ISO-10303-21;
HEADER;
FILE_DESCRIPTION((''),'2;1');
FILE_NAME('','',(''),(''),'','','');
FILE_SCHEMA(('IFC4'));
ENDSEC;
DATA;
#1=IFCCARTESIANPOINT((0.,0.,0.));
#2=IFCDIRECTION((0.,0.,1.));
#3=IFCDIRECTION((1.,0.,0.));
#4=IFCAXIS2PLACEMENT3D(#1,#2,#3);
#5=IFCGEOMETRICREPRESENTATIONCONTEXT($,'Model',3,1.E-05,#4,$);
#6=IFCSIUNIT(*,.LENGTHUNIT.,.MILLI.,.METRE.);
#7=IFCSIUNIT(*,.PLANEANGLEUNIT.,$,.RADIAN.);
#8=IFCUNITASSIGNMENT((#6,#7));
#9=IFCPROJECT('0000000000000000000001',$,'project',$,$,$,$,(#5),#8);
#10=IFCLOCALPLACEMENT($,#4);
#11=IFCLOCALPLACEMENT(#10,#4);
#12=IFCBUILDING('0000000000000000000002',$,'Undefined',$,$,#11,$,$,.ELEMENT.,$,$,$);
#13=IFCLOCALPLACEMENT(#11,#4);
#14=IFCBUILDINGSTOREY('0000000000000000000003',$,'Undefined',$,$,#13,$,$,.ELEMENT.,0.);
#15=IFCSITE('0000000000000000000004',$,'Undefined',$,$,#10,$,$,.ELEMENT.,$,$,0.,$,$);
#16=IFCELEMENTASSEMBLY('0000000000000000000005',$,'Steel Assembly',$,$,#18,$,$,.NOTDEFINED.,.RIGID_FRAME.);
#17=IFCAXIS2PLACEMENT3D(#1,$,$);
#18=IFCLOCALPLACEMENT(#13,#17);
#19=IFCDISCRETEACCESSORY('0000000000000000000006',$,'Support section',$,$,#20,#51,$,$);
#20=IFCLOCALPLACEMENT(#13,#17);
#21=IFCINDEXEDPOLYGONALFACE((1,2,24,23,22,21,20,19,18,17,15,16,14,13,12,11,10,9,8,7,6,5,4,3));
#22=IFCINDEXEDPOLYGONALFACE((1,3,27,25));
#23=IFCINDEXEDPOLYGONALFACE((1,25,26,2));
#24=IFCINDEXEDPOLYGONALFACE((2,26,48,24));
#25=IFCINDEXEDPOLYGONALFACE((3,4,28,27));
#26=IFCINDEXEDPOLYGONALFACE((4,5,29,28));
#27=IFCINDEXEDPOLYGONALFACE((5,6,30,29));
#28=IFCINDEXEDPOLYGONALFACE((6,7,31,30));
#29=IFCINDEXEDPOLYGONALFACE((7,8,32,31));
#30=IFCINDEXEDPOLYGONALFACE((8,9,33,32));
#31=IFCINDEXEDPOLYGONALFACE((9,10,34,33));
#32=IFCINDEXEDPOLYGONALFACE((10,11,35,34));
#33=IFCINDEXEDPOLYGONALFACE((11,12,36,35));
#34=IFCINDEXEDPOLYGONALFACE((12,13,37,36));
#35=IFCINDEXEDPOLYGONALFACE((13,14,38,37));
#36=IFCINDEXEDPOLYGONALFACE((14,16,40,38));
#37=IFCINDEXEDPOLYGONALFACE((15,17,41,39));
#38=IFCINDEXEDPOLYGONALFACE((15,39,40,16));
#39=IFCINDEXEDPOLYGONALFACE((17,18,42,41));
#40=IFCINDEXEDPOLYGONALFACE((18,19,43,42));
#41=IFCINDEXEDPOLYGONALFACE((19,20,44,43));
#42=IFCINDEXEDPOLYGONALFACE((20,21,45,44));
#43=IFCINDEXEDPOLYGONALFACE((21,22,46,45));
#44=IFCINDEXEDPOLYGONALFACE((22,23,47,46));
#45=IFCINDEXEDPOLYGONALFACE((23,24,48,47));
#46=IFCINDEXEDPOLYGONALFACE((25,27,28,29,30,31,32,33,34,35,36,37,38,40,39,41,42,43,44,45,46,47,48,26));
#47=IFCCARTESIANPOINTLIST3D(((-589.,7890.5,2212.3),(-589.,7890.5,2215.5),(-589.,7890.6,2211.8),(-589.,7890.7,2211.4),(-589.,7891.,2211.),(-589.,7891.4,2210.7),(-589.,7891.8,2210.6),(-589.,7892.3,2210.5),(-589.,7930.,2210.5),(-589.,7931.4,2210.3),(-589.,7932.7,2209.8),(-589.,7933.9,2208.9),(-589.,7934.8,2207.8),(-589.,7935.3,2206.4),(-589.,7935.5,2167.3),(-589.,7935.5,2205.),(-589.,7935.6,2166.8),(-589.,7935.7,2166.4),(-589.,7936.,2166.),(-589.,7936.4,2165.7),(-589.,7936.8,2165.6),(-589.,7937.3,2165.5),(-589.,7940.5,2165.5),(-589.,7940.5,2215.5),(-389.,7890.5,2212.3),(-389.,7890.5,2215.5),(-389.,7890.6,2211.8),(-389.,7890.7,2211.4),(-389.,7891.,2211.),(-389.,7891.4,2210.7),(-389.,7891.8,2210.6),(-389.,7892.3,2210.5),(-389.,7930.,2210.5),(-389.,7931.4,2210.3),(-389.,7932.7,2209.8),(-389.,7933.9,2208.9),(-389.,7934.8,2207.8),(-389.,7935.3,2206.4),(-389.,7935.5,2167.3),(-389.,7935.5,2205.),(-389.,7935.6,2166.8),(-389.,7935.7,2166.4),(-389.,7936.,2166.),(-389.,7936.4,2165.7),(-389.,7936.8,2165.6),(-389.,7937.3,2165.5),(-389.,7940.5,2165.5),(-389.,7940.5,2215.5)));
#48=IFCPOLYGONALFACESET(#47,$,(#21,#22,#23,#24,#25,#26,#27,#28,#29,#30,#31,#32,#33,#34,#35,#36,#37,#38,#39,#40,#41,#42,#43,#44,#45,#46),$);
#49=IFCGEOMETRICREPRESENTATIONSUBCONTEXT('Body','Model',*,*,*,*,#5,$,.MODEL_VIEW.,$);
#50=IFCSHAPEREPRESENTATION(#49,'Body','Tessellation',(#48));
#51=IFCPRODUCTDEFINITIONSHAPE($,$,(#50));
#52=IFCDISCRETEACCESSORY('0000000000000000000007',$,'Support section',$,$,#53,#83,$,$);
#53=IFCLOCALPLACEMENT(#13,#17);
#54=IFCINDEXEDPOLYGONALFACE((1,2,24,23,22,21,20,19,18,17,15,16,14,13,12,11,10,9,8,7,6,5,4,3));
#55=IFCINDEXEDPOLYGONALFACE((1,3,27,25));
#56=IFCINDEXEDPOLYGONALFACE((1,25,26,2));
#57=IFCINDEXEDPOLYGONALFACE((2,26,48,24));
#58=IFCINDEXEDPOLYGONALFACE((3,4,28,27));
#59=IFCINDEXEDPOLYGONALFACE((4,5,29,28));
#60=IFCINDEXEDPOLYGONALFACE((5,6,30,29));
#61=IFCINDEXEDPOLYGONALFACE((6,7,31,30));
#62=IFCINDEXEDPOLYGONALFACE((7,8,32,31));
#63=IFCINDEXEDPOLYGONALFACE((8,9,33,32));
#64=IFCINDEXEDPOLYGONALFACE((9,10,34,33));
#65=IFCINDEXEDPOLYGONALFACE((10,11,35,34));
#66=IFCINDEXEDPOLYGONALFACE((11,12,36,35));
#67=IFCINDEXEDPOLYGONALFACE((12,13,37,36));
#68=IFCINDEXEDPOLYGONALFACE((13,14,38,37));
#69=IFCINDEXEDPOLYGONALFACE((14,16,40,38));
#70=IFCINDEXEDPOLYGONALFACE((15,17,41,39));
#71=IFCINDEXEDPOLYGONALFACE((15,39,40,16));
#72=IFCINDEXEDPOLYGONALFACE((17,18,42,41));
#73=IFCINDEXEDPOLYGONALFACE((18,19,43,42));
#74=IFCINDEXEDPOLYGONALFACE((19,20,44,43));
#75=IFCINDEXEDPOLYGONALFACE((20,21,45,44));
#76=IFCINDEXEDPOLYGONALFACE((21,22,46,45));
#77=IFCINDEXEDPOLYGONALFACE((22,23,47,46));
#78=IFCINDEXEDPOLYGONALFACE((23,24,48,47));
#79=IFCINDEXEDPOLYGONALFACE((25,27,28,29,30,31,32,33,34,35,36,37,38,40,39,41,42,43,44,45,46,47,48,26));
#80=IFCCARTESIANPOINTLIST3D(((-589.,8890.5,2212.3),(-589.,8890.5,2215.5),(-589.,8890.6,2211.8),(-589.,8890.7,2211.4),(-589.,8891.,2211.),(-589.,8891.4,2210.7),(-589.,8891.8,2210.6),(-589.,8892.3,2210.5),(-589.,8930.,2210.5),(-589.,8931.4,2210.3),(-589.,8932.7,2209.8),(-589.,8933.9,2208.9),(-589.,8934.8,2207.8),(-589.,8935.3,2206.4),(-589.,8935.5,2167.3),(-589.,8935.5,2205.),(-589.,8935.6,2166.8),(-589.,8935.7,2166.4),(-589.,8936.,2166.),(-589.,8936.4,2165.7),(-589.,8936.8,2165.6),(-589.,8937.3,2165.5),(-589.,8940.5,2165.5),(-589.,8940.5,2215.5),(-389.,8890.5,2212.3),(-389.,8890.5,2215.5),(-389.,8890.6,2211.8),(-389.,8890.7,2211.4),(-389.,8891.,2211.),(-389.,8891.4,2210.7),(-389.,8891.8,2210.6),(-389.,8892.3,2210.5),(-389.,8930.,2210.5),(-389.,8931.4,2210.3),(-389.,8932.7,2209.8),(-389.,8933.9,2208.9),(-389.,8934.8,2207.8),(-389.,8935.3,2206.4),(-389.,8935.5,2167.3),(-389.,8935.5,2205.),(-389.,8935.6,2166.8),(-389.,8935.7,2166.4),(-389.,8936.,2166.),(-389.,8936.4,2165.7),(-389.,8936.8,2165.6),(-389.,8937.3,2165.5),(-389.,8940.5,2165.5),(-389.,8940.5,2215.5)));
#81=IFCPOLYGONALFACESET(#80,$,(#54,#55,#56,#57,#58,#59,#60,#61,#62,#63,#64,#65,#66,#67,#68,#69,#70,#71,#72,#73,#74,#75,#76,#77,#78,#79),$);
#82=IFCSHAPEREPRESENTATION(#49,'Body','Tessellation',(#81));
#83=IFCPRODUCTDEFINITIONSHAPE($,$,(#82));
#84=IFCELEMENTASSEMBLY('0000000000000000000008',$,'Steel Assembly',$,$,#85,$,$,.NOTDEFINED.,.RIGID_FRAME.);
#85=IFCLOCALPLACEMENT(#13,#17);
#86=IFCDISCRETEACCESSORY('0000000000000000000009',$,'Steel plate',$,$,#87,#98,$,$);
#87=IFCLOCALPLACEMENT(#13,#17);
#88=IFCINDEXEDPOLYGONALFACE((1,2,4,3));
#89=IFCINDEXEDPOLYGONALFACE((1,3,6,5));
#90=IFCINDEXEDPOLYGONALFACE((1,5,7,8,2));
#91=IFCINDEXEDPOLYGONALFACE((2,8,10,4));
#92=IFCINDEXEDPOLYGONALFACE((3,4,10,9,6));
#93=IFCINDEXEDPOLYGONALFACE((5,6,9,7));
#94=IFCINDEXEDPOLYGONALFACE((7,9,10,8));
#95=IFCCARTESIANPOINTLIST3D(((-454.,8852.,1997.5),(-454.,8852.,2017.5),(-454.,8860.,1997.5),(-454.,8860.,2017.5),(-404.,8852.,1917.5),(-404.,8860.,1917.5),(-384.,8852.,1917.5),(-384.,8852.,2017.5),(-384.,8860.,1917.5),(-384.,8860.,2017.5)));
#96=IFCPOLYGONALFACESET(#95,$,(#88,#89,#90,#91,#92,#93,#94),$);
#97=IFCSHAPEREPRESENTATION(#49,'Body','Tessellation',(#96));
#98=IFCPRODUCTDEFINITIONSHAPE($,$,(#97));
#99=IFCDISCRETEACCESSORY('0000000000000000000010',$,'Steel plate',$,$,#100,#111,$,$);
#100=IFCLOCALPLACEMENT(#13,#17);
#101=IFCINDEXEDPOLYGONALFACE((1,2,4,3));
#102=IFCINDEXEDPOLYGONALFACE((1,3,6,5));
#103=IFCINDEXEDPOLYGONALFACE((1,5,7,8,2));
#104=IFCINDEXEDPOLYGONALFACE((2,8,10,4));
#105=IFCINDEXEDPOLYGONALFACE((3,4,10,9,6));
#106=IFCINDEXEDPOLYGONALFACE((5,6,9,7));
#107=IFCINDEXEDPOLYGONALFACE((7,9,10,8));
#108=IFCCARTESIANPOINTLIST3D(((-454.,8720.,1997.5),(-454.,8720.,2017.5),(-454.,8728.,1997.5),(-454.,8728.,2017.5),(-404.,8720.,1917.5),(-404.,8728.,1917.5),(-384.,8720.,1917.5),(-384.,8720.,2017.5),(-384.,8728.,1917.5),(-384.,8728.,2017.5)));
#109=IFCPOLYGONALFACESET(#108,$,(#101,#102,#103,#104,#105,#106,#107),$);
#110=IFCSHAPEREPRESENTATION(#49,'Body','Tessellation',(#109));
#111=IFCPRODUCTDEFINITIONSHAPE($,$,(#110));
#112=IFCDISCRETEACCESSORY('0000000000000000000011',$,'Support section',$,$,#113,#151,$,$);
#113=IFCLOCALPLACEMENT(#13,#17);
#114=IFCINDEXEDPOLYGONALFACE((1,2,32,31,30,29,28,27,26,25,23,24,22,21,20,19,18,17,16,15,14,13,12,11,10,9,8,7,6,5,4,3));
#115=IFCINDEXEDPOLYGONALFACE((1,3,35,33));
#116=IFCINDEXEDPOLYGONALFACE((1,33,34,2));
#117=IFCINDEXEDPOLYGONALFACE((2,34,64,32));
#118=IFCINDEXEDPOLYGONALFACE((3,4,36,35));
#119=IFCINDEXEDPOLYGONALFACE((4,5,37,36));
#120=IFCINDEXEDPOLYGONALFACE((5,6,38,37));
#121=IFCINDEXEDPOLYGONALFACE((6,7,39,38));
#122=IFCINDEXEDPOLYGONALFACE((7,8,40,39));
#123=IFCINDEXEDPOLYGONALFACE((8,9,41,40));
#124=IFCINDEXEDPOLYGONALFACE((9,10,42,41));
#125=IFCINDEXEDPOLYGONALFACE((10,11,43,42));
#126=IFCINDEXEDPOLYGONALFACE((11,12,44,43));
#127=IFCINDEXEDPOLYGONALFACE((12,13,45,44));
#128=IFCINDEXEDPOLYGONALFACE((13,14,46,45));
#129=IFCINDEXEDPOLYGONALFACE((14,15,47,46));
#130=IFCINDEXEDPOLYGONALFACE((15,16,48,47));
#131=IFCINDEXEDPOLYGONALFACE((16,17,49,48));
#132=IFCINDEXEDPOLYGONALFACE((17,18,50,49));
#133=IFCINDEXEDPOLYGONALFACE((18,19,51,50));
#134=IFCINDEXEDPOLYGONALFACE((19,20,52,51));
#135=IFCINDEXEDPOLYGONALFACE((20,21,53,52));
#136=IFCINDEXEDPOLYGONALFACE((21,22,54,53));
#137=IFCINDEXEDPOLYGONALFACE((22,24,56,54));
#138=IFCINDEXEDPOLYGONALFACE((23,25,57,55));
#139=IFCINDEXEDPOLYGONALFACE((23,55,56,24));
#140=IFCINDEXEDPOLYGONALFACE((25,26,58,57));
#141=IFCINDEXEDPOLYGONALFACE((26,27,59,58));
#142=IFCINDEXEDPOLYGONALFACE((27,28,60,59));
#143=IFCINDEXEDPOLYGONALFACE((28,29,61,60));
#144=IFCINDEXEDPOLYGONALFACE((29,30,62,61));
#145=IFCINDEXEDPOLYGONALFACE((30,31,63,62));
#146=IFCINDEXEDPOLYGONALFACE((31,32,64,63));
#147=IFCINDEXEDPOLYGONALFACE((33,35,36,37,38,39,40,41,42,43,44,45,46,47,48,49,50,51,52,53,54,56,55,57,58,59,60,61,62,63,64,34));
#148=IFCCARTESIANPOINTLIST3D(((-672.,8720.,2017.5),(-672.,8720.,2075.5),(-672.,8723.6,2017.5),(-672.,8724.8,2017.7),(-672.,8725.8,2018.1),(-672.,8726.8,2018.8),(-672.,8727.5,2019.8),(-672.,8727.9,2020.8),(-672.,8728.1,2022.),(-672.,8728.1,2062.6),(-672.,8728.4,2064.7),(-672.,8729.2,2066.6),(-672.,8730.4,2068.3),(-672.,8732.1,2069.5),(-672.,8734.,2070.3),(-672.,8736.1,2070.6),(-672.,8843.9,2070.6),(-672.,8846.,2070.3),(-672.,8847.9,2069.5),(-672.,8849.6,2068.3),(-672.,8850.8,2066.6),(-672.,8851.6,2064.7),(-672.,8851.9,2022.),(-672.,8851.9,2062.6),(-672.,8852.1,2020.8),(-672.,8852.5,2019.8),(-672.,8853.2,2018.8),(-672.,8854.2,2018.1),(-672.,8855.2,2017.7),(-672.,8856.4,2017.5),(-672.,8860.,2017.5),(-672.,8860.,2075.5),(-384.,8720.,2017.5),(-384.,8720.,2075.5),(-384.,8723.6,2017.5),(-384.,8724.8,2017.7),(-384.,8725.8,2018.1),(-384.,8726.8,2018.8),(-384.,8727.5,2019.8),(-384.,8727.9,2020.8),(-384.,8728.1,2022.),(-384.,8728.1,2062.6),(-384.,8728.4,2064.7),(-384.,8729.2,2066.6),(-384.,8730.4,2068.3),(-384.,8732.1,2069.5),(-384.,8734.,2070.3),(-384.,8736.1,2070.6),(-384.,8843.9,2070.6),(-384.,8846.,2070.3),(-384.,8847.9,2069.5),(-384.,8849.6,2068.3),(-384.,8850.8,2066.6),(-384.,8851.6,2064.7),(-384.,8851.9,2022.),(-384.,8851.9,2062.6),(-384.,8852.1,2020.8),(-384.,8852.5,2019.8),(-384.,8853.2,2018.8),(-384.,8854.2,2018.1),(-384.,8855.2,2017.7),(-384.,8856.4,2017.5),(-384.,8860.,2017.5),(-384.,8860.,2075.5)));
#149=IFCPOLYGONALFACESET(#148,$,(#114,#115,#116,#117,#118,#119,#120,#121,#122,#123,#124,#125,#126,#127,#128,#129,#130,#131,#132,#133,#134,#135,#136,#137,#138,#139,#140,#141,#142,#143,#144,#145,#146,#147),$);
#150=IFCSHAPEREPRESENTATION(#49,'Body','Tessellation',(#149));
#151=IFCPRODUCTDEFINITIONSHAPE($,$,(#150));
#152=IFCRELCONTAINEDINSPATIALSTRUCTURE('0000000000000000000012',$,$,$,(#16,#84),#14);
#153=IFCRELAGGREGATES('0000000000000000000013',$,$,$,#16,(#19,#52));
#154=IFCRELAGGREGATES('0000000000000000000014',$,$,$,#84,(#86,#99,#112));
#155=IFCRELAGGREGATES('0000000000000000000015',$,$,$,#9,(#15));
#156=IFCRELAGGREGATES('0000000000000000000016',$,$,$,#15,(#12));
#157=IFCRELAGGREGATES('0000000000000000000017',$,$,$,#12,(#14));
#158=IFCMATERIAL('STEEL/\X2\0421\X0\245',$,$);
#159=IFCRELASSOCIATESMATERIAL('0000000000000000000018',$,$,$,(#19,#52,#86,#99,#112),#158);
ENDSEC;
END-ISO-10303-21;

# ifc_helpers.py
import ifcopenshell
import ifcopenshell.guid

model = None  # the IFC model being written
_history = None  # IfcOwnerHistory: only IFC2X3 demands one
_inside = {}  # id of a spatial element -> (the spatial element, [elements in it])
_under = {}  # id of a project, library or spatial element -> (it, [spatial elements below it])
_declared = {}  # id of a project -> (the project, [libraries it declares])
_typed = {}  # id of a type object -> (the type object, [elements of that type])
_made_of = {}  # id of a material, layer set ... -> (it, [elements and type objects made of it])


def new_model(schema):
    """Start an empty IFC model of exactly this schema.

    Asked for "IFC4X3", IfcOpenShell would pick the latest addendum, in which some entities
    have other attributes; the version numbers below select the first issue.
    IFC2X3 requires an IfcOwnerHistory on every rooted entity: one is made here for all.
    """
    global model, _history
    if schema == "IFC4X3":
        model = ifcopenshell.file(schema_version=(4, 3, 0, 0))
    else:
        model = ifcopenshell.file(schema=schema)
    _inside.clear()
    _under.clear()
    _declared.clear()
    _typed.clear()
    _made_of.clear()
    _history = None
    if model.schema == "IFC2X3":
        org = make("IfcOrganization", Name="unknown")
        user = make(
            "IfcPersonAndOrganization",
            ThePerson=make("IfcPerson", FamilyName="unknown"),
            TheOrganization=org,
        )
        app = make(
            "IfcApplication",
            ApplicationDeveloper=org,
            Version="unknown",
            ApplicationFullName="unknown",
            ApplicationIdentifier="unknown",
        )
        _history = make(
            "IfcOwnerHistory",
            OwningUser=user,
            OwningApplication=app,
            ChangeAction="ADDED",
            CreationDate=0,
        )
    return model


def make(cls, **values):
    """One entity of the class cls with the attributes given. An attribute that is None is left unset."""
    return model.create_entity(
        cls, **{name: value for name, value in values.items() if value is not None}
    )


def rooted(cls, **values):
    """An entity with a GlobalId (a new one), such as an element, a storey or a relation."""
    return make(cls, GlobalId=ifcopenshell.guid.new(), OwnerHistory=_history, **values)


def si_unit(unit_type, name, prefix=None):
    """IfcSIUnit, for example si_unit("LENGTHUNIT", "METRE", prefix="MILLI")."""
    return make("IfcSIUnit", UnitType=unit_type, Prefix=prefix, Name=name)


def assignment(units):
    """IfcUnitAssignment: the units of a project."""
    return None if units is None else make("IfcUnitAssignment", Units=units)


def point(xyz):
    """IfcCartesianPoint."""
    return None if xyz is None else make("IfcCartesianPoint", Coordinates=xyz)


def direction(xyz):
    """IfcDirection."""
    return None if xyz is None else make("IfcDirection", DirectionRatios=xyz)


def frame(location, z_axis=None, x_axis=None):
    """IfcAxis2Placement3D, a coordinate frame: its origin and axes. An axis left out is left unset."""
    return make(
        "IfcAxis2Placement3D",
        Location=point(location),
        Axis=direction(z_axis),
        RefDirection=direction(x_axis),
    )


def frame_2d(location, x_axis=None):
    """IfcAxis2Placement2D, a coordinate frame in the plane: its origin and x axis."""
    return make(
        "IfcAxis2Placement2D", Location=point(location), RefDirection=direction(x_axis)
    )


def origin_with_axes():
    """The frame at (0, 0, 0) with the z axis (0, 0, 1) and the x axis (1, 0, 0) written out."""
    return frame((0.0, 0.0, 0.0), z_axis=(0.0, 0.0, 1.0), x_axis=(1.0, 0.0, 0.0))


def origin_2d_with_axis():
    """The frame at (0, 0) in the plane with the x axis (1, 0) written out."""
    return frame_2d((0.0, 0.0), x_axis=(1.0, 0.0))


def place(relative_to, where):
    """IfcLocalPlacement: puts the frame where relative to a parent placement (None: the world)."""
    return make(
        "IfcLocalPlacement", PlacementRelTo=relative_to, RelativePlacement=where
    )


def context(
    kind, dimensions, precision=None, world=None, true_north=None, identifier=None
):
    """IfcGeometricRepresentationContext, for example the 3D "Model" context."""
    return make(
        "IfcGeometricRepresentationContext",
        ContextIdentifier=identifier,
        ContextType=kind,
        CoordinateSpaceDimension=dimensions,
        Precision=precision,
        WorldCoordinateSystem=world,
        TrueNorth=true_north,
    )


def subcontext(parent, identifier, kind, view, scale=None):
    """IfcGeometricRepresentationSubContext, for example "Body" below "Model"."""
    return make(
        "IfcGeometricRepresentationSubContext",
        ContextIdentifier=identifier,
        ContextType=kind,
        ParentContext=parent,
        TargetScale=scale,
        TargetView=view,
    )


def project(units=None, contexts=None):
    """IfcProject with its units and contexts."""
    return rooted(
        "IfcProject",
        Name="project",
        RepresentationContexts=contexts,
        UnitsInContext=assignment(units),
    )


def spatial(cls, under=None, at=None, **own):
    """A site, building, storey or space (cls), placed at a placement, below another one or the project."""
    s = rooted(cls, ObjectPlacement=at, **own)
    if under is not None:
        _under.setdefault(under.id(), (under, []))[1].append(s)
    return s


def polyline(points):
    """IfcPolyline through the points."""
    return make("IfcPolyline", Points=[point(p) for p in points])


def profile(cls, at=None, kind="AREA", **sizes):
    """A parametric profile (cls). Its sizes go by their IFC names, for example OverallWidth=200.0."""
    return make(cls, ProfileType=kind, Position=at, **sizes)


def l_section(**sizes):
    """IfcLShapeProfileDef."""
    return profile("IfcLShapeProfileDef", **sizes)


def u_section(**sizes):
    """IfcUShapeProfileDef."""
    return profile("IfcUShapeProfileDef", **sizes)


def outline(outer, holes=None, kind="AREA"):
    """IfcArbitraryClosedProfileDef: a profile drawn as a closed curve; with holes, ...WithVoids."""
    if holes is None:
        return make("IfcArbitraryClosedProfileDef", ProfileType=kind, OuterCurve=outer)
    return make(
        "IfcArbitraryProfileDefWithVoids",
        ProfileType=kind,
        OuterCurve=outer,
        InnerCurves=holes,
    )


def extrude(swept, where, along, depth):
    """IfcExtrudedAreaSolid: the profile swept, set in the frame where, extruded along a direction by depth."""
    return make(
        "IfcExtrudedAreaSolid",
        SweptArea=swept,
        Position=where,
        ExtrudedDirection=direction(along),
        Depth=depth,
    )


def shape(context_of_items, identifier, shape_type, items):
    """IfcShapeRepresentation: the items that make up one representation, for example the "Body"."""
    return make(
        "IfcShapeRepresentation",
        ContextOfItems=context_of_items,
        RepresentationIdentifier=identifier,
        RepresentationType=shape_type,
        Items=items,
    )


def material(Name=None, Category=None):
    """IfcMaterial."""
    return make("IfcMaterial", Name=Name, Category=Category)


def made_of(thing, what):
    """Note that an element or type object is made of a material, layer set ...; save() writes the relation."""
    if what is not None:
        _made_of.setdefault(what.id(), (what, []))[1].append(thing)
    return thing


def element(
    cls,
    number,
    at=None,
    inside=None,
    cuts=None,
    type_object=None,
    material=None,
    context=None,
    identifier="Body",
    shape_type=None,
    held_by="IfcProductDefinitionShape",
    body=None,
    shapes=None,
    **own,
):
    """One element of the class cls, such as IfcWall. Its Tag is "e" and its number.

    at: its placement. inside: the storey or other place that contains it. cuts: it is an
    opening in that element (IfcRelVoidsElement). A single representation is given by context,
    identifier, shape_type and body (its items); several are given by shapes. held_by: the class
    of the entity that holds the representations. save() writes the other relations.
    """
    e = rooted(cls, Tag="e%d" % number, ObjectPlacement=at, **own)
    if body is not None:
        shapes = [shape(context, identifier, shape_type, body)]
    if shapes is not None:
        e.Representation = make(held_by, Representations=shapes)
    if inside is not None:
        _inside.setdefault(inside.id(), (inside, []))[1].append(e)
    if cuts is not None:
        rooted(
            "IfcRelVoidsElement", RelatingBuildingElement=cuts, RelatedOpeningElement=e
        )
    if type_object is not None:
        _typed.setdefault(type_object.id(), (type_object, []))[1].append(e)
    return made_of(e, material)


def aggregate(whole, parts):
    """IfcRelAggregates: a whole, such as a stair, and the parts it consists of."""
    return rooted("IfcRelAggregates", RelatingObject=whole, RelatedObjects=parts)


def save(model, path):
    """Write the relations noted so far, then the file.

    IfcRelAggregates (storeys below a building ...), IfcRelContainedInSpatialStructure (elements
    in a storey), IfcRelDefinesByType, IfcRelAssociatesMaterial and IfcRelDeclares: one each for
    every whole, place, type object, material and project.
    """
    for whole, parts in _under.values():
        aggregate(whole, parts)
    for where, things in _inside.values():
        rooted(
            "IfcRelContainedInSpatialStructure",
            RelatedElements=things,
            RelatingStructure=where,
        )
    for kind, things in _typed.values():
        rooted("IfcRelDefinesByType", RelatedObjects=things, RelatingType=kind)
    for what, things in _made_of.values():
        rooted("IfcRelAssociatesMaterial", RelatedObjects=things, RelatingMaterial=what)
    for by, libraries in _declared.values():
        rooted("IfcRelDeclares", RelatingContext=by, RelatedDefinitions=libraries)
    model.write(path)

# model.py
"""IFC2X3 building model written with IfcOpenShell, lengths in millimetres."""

from ifc_helpers import new_model, si_unit, frame, origin_with_axes, origin_2d_with_axis, place, context, subcontext, project, spatial, polyline, l_section, u_section, outline, extrude, material, element, aggregate, save


model = new_model("IFC2X3")

# Units and contexts
model_context = context("Model", 3, precision=1e-05, world=origin_with_axes())
body_context = subcontext(model_context, "Body", "Model", "MODEL_VIEW")
ifc_project = project(units=[si_unit("LENGTHUNIT", "METRE", prefix="MILLI"), si_unit("PLANEANGLEUNIT", "RADIAN")], contexts=[model_context])

# Site, building, storey
site_placement = place(None, origin_with_axes())
site = spatial("IfcSite", under=ifc_project, at=site_placement, Name="Undefined", CompositionType="ELEMENT", RefElevation=0.0)
building_placement = place(site_placement, origin_with_axes())
building = spatial("IfcBuilding", under=site, at=building_placement, Name="Undefined", CompositionType="ELEMENT")
storey_placement = place(building_placement, origin_with_axes())
storey = spatial("IfcBuildingStorey", under=building, at=storey_placement, Name="Undefined", CompositionType="ELEMENT", Elevation=0.0)

# Shared definitions
ifc_material_1 = material(Name="STEEL/С245")

# Element assemblies, discrete accessories
assembly_1_placement = place(storey_placement, origin_with_axes())
assembly_1 = element("IfcElementAssembly", 1, at=assembly_1_placement, inside=storey, Name="Steel Assembly", AssemblyPlace="NOTDEFINED", PredefinedType="RIGID_FRAME")
discrete_accessory_1_placement = place(assembly_1_placement, frame((-589.0, 7915.5, 2190.5), z_axis=(0.0, -1.0, 0.0), x_axis=(1.0, 0.0, 0.0)))
discrete_accessory_1 = element("IfcDiscreteAccessory", 2, at=discrete_accessory_1_placement, material=ifc_material_1, Name="Support section", context=body_context, shape_type="SweptSolid", body=[
    extrude(l_section(Depth=50.0, Width=50.0, Thickness=5.0, FilletRadius=5.5, EdgeRadius=1.8, at=origin_2d_with_axis()), frame((200.0, 0.0, 0.0), z_axis=(-1.0, 0.0, 0.0), x_axis=(0.0, -1.0, 0.0)), (0.0, 0.0, 1.0), 200.0),
])
discrete_accessory_2_placement = place(assembly_1_placement, frame((-589.0, 8915.5, 2190.5), z_axis=(0.0, -1.0, 0.0), x_axis=(1.0, 0.0, 0.0)))
discrete_accessory_2 = element("IfcDiscreteAccessory", 3, at=discrete_accessory_2_placement, material=ifc_material_1, Name="Support section", context=body_context, shape_type="SweptSolid", body=[
    extrude(l_section(Depth=50.0, Width=50.0, Thickness=5.0, FilletRadius=5.5, EdgeRadius=1.8, at=origin_2d_with_axis()), frame((200.0, 0.0, 0.0), z_axis=(-1.0, 0.0, 0.0), x_axis=(0.0, -1.0, 0.0)), (0.0, 0.0, 1.0), 200.0),
])
aggregate(assembly_1, [discrete_accessory_1, discrete_accessory_2])
assembly_2_placement = place(storey_placement, origin_with_axes())
assembly_2 = element("IfcElementAssembly", 4, at=assembly_2_placement, inside=storey, Name="Steel Assembly", AssemblyPlace="NOTDEFINED", PredefinedType="RIGID_FRAME")
discrete_accessory_3_placement = place(assembly_2_placement, frame((-384.0, 8856.0, 2017.5), z_axis=(0.0, 1.0, 0.0), x_axis=(0.0, 0.0, -1.0)))
discrete_accessory_3 = element("IfcDiscreteAccessory", 5, at=discrete_accessory_3_placement, material=ifc_material_1, Name="Steel plate", context=body_context, shape_type="SweptSolid", body=[
    extrude(outline(polyline([(0.0, 0.0), (100.0, 0.0), (100.0, 20.0), (20.0, 70.0), (0.0, 70.0), (0.0, 0.0)])), frame((0.0, 0.0, -4.0), z_axis=(0.0, 0.0, 1.0), x_axis=(1.0, 0.0, 0.0)), (0.0, 0.0, 1.0), 8.0),
])
discrete_accessory_4_placement = place(assembly_2_placement, frame((-384.0, 8724.0, 2017.5), z_axis=(0.0, 1.0, 0.0), x_axis=(0.0, 0.0, -1.0)))
discrete_accessory_4 = element("IfcDiscreteAccessory", 6, at=discrete_accessory_4_placement, material=ifc_material_1, Name="Steel plate", context=body_context, shape_type="SweptSolid", body=[
    extrude(outline(polyline([(0.0, 0.0), (100.0, 0.0), (100.0, 20.0), (20.0, 70.0), (0.0, 70.0), (0.0, 0.0)])), frame((0.0, 0.0, -4.0), z_axis=(0.0, 0.0, 1.0), x_axis=(1.0, 0.0, 0.0)), (0.0, 0.0, 1.0), 8.0),
])
discrete_accessory_5_placement = place(assembly_2_placement, frame((-384.0, 8790.0, 2046.5), z_axis=(0.0, 1.0, 0.0), x_axis=(-1.0, 0.0, 0.0)))
discrete_accessory_5 = element("IfcDiscreteAccessory", 7, at=discrete_accessory_5_placement, material=ifc_material_1, Name="Support section", context=body_context, shape_type="SweptSolid", body=[
    extrude(u_section(Depth=140.0, FlangeWidth=58.0, WebThickness=4.9, FlangeThickness=8.1, FilletRadius=8.0, EdgeRadius=4.5, at=origin_2d_with_axis()), frame((288.0, 0.0, 0.0), z_axis=(-1.0, 0.0, 0.0), x_axis=(0.0, -1.0, 0.0)), (0.0, 0.0, 1.0), 288.0),
])

aggregate(assembly_2, [discrete_accessory_3, discrete_accessory_4, discrete_accessory_5])

save(model, "model.ifc")
